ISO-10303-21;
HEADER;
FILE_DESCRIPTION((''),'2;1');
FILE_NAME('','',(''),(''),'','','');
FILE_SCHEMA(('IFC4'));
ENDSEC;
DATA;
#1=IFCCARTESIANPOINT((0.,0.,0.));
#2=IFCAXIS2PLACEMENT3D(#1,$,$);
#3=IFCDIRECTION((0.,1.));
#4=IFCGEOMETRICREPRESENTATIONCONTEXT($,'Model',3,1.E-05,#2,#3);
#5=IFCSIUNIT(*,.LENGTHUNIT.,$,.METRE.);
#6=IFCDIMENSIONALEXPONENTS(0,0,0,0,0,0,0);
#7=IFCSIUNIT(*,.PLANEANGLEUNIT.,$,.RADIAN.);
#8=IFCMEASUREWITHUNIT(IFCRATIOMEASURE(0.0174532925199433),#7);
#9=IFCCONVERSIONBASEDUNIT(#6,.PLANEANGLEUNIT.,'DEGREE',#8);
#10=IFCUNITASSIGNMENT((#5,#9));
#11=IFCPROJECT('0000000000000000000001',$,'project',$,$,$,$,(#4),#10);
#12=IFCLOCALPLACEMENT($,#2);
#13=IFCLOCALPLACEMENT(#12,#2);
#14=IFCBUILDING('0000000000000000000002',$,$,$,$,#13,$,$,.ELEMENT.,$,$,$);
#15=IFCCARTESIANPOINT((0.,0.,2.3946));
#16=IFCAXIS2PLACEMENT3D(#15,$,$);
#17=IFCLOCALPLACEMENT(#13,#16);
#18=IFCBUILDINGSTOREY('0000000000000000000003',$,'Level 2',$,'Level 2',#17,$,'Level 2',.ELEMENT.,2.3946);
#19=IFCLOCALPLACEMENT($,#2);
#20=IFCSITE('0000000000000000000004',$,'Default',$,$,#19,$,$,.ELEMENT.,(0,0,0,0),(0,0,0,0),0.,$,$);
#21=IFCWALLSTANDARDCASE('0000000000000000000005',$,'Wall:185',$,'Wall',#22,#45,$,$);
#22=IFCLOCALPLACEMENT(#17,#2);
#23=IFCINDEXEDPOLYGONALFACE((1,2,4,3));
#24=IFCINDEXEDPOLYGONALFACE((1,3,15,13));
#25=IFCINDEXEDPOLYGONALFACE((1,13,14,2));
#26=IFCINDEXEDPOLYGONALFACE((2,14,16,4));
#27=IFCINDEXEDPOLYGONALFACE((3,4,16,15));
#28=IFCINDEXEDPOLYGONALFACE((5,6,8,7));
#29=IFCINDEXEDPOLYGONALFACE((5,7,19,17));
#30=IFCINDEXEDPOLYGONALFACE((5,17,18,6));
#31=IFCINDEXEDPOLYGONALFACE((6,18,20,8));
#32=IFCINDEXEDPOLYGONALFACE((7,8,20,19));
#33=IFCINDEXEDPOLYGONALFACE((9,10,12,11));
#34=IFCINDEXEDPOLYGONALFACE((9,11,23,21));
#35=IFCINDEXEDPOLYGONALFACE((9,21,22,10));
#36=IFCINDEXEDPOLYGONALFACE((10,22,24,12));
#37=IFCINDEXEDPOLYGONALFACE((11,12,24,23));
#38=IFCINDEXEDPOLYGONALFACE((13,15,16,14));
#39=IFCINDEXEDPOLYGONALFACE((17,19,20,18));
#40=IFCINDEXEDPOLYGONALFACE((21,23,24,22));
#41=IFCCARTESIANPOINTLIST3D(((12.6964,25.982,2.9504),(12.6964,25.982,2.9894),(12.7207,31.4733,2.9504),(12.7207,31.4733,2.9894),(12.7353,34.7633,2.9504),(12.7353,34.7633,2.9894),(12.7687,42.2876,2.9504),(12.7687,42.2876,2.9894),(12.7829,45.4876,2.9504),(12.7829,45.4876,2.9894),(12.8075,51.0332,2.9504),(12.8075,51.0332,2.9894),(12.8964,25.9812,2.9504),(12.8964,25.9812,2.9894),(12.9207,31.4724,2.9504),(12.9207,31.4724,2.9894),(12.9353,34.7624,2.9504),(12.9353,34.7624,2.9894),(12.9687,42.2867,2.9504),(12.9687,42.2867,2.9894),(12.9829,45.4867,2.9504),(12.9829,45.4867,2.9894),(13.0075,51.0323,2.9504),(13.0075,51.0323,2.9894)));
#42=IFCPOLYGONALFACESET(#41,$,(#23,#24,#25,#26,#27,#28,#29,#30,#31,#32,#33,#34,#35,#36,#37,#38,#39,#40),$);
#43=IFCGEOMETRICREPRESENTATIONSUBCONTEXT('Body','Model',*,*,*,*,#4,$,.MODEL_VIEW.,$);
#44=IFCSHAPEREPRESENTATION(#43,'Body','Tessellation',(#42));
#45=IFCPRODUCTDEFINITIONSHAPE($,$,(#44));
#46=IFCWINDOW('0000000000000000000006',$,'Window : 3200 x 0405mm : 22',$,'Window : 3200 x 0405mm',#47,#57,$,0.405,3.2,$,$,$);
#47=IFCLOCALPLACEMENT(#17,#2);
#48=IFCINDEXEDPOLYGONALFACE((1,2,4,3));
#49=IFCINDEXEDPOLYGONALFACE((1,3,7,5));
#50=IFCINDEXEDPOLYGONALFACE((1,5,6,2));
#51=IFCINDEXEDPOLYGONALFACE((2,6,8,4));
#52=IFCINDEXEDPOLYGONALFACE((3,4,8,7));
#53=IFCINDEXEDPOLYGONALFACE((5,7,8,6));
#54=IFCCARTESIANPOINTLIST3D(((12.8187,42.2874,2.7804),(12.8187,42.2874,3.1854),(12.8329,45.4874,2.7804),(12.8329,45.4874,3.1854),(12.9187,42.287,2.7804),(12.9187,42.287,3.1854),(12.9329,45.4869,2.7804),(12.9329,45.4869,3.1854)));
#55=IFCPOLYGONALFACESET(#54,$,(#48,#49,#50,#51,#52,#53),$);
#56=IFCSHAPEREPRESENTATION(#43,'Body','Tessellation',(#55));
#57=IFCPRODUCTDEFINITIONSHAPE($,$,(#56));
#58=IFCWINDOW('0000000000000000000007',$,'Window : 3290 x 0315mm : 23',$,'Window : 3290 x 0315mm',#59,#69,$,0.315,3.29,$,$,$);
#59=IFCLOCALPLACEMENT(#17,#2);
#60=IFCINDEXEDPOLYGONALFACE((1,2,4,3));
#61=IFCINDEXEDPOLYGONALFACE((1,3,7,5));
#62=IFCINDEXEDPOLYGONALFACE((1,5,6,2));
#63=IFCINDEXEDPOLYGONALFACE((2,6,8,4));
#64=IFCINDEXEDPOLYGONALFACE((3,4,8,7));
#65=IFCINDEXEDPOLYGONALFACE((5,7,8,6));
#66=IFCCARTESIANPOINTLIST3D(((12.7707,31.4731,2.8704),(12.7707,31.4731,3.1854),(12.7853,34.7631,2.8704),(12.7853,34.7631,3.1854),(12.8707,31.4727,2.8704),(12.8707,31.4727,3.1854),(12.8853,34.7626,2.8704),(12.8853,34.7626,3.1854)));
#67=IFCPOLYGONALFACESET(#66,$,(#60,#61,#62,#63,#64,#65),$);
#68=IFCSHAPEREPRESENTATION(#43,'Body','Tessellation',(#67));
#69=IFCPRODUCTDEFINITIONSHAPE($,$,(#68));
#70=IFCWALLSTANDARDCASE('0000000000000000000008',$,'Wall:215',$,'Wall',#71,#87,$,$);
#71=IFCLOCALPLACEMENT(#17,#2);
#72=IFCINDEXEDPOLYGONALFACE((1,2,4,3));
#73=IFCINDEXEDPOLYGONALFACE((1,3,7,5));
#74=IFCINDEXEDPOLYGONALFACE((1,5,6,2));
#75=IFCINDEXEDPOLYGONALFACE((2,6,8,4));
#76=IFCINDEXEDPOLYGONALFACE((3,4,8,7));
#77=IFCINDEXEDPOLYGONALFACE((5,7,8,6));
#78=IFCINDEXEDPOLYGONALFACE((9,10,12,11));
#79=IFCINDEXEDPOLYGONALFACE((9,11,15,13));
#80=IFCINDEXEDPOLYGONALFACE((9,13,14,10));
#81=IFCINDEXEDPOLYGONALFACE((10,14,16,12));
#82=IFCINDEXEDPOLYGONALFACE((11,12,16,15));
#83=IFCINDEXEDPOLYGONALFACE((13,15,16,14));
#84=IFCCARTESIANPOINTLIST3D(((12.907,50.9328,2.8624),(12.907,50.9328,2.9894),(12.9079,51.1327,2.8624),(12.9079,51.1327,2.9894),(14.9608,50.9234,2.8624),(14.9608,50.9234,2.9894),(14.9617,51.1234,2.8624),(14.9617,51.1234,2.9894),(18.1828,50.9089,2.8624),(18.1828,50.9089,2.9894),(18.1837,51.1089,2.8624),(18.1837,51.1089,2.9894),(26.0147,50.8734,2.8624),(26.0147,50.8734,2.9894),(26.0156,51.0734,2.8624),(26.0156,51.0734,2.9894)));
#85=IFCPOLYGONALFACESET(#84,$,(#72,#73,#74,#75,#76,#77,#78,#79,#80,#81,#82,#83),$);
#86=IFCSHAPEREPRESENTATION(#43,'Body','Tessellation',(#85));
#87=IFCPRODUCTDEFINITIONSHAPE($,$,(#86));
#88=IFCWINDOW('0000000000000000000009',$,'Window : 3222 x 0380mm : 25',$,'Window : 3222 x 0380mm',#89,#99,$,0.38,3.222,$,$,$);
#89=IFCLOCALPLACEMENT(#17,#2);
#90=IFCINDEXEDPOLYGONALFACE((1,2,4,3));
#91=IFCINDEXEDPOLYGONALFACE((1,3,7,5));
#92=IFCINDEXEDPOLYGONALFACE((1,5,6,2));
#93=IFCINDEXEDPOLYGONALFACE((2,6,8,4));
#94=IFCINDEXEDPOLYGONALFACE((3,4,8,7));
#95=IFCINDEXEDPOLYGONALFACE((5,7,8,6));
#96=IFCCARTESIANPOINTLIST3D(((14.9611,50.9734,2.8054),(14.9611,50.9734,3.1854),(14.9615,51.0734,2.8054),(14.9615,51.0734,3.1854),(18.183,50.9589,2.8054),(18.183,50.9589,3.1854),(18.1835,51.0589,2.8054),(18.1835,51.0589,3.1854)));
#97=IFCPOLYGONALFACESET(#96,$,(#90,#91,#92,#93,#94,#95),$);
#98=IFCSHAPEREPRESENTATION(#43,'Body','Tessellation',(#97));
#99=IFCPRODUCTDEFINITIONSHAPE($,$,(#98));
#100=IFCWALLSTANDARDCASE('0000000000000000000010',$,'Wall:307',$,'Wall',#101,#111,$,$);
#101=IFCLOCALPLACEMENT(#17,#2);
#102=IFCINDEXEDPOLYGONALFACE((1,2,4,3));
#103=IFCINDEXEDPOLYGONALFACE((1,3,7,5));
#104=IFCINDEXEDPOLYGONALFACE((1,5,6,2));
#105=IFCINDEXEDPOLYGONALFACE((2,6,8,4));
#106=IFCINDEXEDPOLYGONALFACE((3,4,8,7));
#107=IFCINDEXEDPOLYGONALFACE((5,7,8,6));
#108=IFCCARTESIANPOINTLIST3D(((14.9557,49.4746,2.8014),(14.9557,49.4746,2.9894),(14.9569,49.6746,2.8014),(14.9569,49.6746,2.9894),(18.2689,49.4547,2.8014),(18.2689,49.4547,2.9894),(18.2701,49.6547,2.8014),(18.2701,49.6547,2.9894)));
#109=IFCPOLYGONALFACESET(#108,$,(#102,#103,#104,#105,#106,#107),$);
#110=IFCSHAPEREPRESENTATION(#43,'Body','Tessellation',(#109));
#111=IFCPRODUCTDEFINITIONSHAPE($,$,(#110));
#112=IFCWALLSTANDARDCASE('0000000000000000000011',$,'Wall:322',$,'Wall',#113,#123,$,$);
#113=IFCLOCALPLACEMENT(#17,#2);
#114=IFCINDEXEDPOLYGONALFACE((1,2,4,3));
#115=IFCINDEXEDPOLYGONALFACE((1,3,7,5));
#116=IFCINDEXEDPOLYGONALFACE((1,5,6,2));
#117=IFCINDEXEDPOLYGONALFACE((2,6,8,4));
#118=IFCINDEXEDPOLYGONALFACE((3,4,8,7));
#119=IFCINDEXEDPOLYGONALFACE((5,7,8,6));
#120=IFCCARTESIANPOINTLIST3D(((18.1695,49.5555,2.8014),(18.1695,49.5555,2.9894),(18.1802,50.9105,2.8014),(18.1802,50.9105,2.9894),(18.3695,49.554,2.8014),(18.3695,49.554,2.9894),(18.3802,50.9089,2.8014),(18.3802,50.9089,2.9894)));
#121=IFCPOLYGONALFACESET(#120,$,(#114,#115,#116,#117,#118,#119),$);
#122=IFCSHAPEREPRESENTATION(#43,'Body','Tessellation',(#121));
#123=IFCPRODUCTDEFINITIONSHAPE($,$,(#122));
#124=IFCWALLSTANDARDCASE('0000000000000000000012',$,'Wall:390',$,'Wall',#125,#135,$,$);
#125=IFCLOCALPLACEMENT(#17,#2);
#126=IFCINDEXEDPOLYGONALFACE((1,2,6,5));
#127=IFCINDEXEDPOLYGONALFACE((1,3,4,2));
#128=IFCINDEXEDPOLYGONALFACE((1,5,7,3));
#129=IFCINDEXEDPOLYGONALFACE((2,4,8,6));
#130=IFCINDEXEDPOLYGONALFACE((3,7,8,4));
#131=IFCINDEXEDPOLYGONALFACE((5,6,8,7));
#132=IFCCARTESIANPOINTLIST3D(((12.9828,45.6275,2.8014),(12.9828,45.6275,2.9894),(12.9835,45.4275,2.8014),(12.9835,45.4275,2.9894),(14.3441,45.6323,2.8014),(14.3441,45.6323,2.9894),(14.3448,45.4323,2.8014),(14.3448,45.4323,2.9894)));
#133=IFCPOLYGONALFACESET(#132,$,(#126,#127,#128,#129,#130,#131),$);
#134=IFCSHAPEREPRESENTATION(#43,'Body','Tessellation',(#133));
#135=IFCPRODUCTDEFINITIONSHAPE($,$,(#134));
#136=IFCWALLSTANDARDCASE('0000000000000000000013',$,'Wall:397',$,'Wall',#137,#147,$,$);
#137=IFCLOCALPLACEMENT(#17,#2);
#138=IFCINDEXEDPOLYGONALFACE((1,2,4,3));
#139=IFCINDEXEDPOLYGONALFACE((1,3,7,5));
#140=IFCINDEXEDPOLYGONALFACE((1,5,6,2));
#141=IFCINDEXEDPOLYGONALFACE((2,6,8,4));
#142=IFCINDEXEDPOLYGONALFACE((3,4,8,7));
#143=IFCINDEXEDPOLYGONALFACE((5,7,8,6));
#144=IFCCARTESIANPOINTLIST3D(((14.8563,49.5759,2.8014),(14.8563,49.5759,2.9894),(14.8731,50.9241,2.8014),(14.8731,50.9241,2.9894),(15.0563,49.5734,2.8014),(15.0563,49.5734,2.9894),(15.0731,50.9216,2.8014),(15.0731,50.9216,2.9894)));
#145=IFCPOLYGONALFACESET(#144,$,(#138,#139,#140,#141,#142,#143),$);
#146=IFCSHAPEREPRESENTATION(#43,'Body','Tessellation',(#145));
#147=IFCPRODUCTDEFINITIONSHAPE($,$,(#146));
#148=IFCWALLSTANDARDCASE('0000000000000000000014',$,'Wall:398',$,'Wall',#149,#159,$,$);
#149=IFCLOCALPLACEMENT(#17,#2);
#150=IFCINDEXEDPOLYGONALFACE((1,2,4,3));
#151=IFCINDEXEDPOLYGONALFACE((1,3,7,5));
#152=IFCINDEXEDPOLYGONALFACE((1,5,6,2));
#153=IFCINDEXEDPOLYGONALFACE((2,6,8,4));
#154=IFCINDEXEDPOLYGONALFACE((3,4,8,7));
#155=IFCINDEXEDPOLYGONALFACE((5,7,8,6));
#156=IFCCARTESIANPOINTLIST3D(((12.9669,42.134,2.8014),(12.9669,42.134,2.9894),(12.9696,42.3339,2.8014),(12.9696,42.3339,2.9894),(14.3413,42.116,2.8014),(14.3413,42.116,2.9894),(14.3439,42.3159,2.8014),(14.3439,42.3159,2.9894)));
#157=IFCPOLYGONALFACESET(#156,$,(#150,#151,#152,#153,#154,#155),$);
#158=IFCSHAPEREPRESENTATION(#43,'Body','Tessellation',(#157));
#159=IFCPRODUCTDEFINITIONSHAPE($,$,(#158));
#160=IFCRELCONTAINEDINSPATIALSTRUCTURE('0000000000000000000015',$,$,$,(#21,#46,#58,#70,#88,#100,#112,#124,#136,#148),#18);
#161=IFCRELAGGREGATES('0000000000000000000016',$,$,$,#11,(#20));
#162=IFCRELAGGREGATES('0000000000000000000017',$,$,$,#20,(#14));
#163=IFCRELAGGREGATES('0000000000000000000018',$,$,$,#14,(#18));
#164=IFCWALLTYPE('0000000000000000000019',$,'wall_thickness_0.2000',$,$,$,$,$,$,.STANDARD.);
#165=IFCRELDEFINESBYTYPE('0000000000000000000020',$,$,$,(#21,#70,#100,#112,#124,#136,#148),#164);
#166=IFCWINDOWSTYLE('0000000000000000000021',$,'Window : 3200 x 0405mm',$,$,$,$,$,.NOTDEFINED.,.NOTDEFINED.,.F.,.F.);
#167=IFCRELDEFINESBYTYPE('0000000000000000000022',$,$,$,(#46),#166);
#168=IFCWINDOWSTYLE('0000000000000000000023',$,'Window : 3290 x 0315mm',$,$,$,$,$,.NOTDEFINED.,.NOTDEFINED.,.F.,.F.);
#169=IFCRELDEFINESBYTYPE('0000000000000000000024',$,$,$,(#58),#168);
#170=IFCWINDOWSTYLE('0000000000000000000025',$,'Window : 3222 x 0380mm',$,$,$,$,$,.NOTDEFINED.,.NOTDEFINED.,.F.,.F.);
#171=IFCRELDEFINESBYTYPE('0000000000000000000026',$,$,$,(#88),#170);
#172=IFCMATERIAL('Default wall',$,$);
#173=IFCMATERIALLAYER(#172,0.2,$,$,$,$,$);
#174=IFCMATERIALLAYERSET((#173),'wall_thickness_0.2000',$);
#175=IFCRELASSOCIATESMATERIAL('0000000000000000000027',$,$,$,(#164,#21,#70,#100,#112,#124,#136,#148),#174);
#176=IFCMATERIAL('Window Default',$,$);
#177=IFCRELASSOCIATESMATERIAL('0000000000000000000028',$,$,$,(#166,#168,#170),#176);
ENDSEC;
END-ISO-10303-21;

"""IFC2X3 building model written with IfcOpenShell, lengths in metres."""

from ifc_helpers import new_model, entity, si_unit, converted_unit, direction, frame, frame_2d, origin, origin_2d_with_axis, place, context, subcontext, project, spatial, polyline, rectangle, outline, extrude, source, transform, mapped, material, layer, layer_set, layer_usage, type_object, type_shapes, element, fill, save


model = new_model("IFC2X3")

# Units and contexts
model_context = context("Model", 3, precision=1e-05, world=origin(), true_north=direction((0.0, 1.0)))
body_context = subcontext(model_context, "Body", "Model", "MODEL_VIEW")
ifc_project = project(units=[si_unit("LENGTHUNIT", "METRE"), converted_unit("PLANEANGLEUNIT", "DEGREE", entity("IfcRatioMeasure", 0.0174532925199433), si_unit("PLANEANGLEUNIT", "RADIAN"), dimensions=[0, 0, 0, 0, 0, 0, 0])], contexts=[model_context])

# Site, building, storey
site_placement = place(None, origin())
site = spatial("IfcSite", under=ifc_project, at=site_placement, Name="Default", CompositionType="ELEMENT", RefLatitude=(0, 0, 0, 0), RefLongitude=(0, 0, 0, 0), RefElevation=0.0)
placement_1 = place(None, origin())
building_placement = place(placement_1, origin())
building = spatial("IfcBuilding", under=site, at=building_placement, CompositionType="ELEMENT")
storey_placement = place(building_placement, frame((0.0, 0.0, 2.3946)))
storey = spatial("IfcBuildingStorey", under=building, at=storey_placement, Name="Level 2", ObjectType="Level 2", LongName="Level 2", CompositionType="ELEMENT", Elevation=2.3946)

# Shared definitions
ifc_material_1 = material(Name="Default wall")
ifc_material_2 = material(Name="Window Default")

# Wall, openings, windows
ifc_layer_1 = layer(ifc_material_1, 0.2)
ifc_layer_set_1 = layer_set([ifc_layer_1], Name="wall_thickness_0.2000")
ifc_layer_usage_1 = layer_usage(ifc_layer_set_1, "AXIS2", "POSITIVE", -0.1)
wall_type_1 = type_object("IfcWallType", Name="wall_thickness_0.2000", PredefinedType="STANDARD", material=ifc_layer_set_1)
placement_2 = place(building_placement, frame((0.0, 0.0, 5.345)))
wall_1_placement = place(placement_2, frame((12.9075, 51.0328, 0.0), z_axis=(0.0, 0.0, 1.0), x_axis=(-0.004436, -0.99999, 0.0)))
wall_1 = element("IfcWallStandardCase", 1, at=wall_1_placement, inside=storey, type_object=wall_type_1, material=ifc_layer_usage_1, Name="Wall:185", ObjectType="Wall", context=body_context, shape_type="SweptSolid", body=[
    extrude(outline(polyline([(25.0514, -0.1), (25.0514, 0.1), (0.0, 0.1), (0.0, -0.1), (25.0514, -0.1)])), origin(), (0.0, 0.0, 1.0), 0.039),
])
opening_1_placement = place(wall_1_placement, frame((5.5457, -0.1, -0.17)))
opening_1 = element("IfcOpeningElement", 2, at=opening_1_placement, cuts=wall_1, ObjectType="Opening", context=body_context, shape_type="SweptSolid", body=[
    extrude(rectangle(XDim=3.2, YDim=0.405, at=frame_2d((0.2025, 1.6), x_axis=(0.0, 1.0))), frame((0.0, 0.0, 0.0), z_axis=(0.0, 1.0, 0.0), x_axis=(0.0, 0.0, 1.0)), (0.0, 0.0, 1.0), 0.2),
])
opening_2_placement = place(wall_1_placement, frame((16.2701, -0.1, -0.08)))
opening_2 = element("IfcOpeningElement", 3, at=opening_2_placement, cuts=wall_1, ObjectType="Opening", context=body_context, shape_type="SweptSolid", body=[
    extrude(rectangle(XDim=3.29, YDim=0.315, at=frame_2d((0.1575, 1.645), x_axis=(0.0, 1.0))), frame((0.0, 0.0, 0.0), z_axis=(0.0, 1.0, 0.0), x_axis=(0.0, 0.0, 1.0)), (0.0, 0.0, 1.0), 0.2),
])
window_style_1 = type_object("IfcWindowStyle", Name="Window : 3200 x 0405mm", ConstructionType="NOTDEFINED", OperationType="NOTDEFINED", ParameterTakesPrecedence=False, Sizeable=False, material=ifc_material_2)
shared_shape_1 = source(origin(), body_context, "Body", "SweptSolid", [
    extrude(rectangle(XDim=0.1, YDim=3.2, at=origin_2d_with_axis()), frame((1.6, 0.1, 0.0), z_axis=(0.0, 0.0, 1.0), x_axis=(0.0, 1.0, 0.0)), (0.0, 0.0, 1.0), 0.405),
])
type_shapes(window_style_1, [shared_shape_1])
window_1_placement = place(opening_1_placement, origin())
window_1 = element("IfcWindow", 4, at=window_1_placement, inside=storey, type_object=window_style_1, Name="Window : 3200 x 0405mm : 22", ObjectType="Window : 3200 x 0405mm", OverallHeight=0.405, OverallWidth=3.2, context=body_context, shape_type="MappedRepresentation", body=[
    mapped(shared_shape_1, transform((0.0, 0.0, 0.0), scale=1.0)),
])
fill(opening_1, window_1)
window_style_2 = type_object("IfcWindowStyle", Name="Window : 3290 x 0315mm", ConstructionType="NOTDEFINED", OperationType="NOTDEFINED", ParameterTakesPrecedence=False, Sizeable=False, material=ifc_material_2)
shared_shape_2 = source(origin(), body_context, "Body", "SweptSolid", [
    extrude(rectangle(XDim=0.1, YDim=3.29, at=origin_2d_with_axis()), frame((1.645, 0.1, 0.0), z_axis=(0.0, 0.0, 1.0), x_axis=(0.0, 1.0, 0.0)), (0.0, 0.0, 1.0), 0.315),
])
type_shapes(window_style_2, [shared_shape_2])
window_2_placement = place(opening_2_placement, origin())
window_2 = element("IfcWindow", 5, at=window_2_placement, inside=storey, type_object=window_style_2, Name="Window : 3290 x 0315mm : 23", ObjectType="Window : 3290 x 0315mm", OverallHeight=0.315, OverallWidth=3.29, context=body_context, shape_type="MappedRepresentation", body=[
    mapped(shared_shape_2, transform((0.0, 0.0, 0.0), scale=1.0)),
])
fill(opening_2, window_2)

# Wall, opening, window
placement_3 = place(building_placement, frame((0.0, 0.0, 5.257)))
wall_2_placement = place(placement_3, frame((12.9075, 51.0327, 0.0), z_axis=(0.0, 0.0, 1.0), x_axis=(0.99999, -0.004529, 0.0)))
wall_2 = element("IfcWallStandardCase", 6, at=wall_2_placement, inside=storey, type_object=wall_type_1, material=ifc_layer_usage_1, Name="Wall:215", ObjectType="Wall", context=body_context, shape_type="SweptSolid", body=[
    extrude(outline(polyline([(13.1078, -0.1), (13.1078, 0.1), (0.0, 0.1), (0.0, -0.1), (13.1078, -0.1)])), origin(), (0.0, 0.0, 1.0), 0.127),
])
opening_3_placement = place(wall_2_placement, frame((2.0538, -0.1, -0.057)))
opening_3 = element("IfcOpeningElement", 7, at=opening_3_placement, cuts=wall_2, ObjectType="Opening", context=body_context, shape_type="SweptSolid", body=[
    extrude(rectangle(XDim=3.222, YDim=0.38, at=frame_2d((0.19, 1.611), x_axis=(0.0, 1.0))), frame((0.0, 0.0, 0.0), z_axis=(0.0, 1.0, 0.0), x_axis=(0.0, 0.0, 1.0)), (0.0, 0.0, 1.0), 0.2),
])
window_style_3 = type_object("IfcWindowStyle", Name="Window : 3222 x 0380mm", ConstructionType="NOTDEFINED", OperationType="NOTDEFINED", ParameterTakesPrecedence=False, Sizeable=False, material=ifc_material_2)
shared_shape_3 = source(origin(), body_context, "Body", "SweptSolid", [
    extrude(rectangle(XDim=0.1, YDim=3.222, at=origin_2d_with_axis()), frame((1.611, 0.1, 0.0), z_axis=(0.0, 0.0, 1.0), x_axis=(0.0, 1.0, 0.0)), (0.0, 0.0, 1.0), 0.38),
])
type_shapes(window_style_3, [shared_shape_3])
window_3_placement = place(opening_3_placement, origin())
window_3 = element("IfcWindow", 8, at=window_3_placement, inside=storey, type_object=window_style_3, Name="Window : 3222 x 0380mm : 25", ObjectType="Window : 3222 x 0380mm", OverallHeight=0.38, OverallWidth=3.222, context=body_context, shape_type="MappedRepresentation", body=[
    mapped(shared_shape_3, transform((0.0, 0.0, 0.0), scale=1.0)),
])
fill(opening_3, window_3)

# Walls
placement_4 = place(building_placement, frame((0.0, 0.0, 5.196)))
wall_3_placement = place(placement_4, frame((14.9563, 49.5746, 0.0), z_axis=(0.0, 0.0, 1.0), x_axis=(0.999982, -0.006003, 0.0)))
element("IfcWallStandardCase", 9, at=wall_3_placement, inside=storey, type_object=wall_type_1, material=ifc_layer_usage_1, Name="Wall:307", ObjectType="Wall", context=body_context, shape_type="SweptSolid", body=[
    extrude(outline(polyline([(3.3133, -0.1), (3.3133, 0.1), (0.0, 0.1), (0.0, -0.1), (3.3133, -0.1)])), origin(), (0.0, 0.0, 1.0), 0.188),
])
placement_5 = place(building_placement, frame((0.0, 0.0, 5.196)))
wall_4_placement = place(placement_5, frame((18.2802, 50.9097, 0.0), z_axis=(0.0, 0.0, 1.0), x_axis=(-0.007871, -0.999969, 0.0)))
element("IfcWallStandardCase", 10, at=wall_4_placement, inside=storey, type_object=wall_type_1, material=ifc_layer_usage_1, Name="Wall:322", ObjectType="Wall", context=body_context, shape_type="SweptSolid", body=[
    extrude(outline(polyline([(1.355, -0.1), (1.355, 0.1), (0.0, 0.1), (0.0, -0.1), (1.355, -0.1)])), origin(), (0.0, 0.0, 1.0), 0.188),
])
placement_6 = place(building_placement, frame((0.0, 0.0, 5.196)))
wall_5_placement = place(placement_6, frame((12.9832, 45.5275, 0.0), z_axis=(0.0, 0.0, 1.0), x_axis=(0.999994, 0.003531, 0.0)))
element("IfcWallStandardCase", 11, at=wall_5_placement, inside=storey, type_object=wall_type_1, material=ifc_layer_usage_1, Name="Wall:390", ObjectType="Wall", context=body_context, shape_type="SweptSolid", body=[
    extrude(outline(polyline([(1.3612, -0.1), (1.3612, 0.1), (0.0, 0.1), (0.0, -0.1), (1.3612, -0.1)])), origin(), (0.0, 0.0, 1.0), 0.188),
])
placement_7 = place(building_placement, frame((0.0, 0.0, 5.196)))
wall_6_placement = place(placement_7, frame((14.9563, 49.5746, 0.0), z_axis=(0.0, 0.0, 1.0), x_axis=(0.012455, 0.999922, 0.0)))
element("IfcWallStandardCase", 12, at=wall_6_placement, inside=storey, type_object=wall_type_1, material=ifc_layer_usage_1, Name="Wall:397", ObjectType="Wall", context=body_context, shape_type="SweptSolid", body=[
    extrude(outline(polyline([(1.3483, -0.1), (1.3483, 0.1), (0.0, 0.1), (0.0, -0.1), (1.3483, -0.1)])), origin(), (0.0, 0.0, 1.0), 0.188),
])
placement_8 = place(building_placement, frame((0.0, 0.0, 5.196)))
wall_7_placement = place(placement_8, frame((12.9682, 42.2339, 0.0), z_axis=(0.0, 0.0, 1.0), x_axis=(0.999914, -0.013086, 0.0)))
element("IfcWallStandardCase", 13, at=wall_7_placement, inside=storey, type_object=wall_type_1, material=ifc_layer_usage_1, Name="Wall:398", ObjectType="Wall", context=body_context, shape_type="SweptSolid", body=[
    extrude(outline(polyline([(1.3745, -0.1), (1.3745, 0.1), (0.0, 0.1), (0.0, -0.1), (1.3745, -0.1)])), origin(), (0.0, 0.0, 1.0), 0.188),
])

save(model, "model.ifc")
